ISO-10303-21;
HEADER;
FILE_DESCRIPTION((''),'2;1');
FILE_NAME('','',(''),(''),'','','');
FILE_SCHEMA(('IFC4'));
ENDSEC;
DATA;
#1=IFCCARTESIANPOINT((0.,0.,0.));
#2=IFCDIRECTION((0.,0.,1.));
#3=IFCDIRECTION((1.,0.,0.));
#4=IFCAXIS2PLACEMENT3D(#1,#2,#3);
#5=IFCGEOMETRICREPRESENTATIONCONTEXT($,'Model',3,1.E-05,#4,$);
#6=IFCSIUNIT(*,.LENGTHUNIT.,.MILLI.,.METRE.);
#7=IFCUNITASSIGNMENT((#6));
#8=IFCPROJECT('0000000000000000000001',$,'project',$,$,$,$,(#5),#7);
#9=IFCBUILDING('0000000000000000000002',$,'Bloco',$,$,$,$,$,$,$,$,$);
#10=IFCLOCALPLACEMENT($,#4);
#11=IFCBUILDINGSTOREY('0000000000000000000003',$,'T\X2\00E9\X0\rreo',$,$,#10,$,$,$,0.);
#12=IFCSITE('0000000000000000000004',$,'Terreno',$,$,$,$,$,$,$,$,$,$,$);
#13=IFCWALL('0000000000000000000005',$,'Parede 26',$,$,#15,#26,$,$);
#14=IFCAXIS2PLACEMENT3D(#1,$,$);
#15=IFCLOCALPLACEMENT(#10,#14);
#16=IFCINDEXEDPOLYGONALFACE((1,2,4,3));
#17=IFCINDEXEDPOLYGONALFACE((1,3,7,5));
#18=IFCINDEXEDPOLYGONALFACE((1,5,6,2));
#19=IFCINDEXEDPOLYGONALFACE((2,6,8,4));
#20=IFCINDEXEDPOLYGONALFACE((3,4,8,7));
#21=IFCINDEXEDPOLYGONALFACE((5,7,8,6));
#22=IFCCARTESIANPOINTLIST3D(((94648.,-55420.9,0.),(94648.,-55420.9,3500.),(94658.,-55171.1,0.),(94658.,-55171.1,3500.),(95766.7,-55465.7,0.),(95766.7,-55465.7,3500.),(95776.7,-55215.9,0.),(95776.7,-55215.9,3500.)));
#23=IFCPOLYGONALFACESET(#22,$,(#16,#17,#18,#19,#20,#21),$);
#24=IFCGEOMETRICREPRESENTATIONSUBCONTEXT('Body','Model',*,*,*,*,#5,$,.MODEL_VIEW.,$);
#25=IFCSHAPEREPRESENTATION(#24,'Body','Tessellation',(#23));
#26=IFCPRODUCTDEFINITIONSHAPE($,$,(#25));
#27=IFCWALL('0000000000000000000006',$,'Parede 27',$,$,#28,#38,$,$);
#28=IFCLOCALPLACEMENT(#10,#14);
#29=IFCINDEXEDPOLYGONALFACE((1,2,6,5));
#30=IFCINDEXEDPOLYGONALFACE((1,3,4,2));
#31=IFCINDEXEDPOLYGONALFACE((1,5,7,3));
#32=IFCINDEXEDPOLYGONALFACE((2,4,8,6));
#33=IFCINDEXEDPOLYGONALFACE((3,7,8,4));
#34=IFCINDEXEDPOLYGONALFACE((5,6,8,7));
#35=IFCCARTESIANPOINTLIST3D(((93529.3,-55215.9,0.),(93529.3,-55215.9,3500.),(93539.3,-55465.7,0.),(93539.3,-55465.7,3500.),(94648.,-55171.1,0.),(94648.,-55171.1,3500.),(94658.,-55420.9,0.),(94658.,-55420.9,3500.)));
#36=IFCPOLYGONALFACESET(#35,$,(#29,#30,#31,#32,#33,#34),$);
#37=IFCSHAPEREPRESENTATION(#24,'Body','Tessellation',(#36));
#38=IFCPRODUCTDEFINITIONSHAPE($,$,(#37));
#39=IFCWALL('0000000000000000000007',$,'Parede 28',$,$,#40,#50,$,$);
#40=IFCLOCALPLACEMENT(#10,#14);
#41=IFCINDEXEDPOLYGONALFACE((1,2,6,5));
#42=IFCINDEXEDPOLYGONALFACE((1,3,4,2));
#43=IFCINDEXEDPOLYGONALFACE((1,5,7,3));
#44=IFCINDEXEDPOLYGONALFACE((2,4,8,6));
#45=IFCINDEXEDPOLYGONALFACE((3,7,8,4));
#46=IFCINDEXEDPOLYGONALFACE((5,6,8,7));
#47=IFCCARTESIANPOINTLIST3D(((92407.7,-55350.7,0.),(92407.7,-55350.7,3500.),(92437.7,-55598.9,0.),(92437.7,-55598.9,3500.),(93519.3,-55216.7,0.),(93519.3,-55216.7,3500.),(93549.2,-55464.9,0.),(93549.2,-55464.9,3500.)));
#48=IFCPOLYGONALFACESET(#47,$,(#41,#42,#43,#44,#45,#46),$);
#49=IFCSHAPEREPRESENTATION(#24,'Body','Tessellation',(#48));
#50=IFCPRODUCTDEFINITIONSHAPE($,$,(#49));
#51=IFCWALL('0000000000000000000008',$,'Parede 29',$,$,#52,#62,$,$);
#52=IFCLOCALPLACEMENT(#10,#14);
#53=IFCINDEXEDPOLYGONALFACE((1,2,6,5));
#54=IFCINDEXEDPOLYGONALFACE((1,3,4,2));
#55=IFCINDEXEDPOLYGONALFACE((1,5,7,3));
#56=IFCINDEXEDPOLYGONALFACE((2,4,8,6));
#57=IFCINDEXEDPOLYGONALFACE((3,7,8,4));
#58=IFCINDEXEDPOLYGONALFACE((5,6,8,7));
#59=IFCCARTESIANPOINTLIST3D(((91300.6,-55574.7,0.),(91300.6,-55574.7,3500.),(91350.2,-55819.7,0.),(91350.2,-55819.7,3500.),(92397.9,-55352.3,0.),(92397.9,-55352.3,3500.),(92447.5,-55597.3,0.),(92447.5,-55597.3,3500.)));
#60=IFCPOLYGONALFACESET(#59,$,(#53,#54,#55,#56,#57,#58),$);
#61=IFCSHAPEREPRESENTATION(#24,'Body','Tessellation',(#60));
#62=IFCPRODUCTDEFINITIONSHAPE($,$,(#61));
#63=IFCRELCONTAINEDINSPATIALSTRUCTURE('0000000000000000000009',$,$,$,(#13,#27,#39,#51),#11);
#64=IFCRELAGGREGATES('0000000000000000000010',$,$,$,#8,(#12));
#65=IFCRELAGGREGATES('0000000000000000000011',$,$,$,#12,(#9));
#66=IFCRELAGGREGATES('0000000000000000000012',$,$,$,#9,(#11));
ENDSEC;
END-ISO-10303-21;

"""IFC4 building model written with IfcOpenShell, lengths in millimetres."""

from ifc_helpers import new_model, si_unit, origin, origin_with_axes, place, context, subcontext, project, spatial, polyline, outline, extrude, element, save


model = new_model("IFC4")

# Units and contexts
model_context = context("Model", 3, precision=1e-05, world=origin_with_axes())
body_context = subcontext(model_context, "Body", "Model", "MODEL_VIEW")
ifc_project = project(units=[si_unit("LENGTHUNIT", "METRE", prefix="MILLI")], contexts=[model_context])

# Site, building, storey
site = spatial("IfcSite", under=ifc_project, Name="Terreno")
building = spatial("IfcBuilding", under=site, Name="Bloco")
storey_placement = place(None, origin_with_axes())
storey = spatial("IfcBuildingStorey", under=building, at=storey_placement, Name="Térreo", Elevation=0.0)

# Walls
wall_1_placement = place(storey_placement, origin_with_axes())
element("IfcWall", 1, at=wall_1_placement, inside=storey, Name="Parede 26", context=body_context, shape_type="SweptSolid", body=[
    extrude(outline(polyline([(95766.7, -55465.7), (94648.0, -55420.9), (94658.0, -55171.1), (95776.7, -55215.9), (95766.7, -55465.7)])), origin(), (0.0, 0.0, 1.0), 3500.0),
])
wall_2_placement = place(storey_placement, origin_with_axes())
element("IfcWall", 2, at=wall_2_placement, inside=storey, Name="Parede 27", context=body_context, shape_type="SweptSolid", body=[
    extrude(outline(polyline([(94658.0, -55420.9), (93539.3, -55465.7), (93529.3, -55215.9), (94648.0, -55171.1), (94658.0, -55420.9)])), origin(), (0.0, 0.0, 1.0), 3500.0),
])
wall_3_placement = place(storey_placement, origin_with_axes())
element("IfcWall", 3, at=wall_3_placement, inside=storey, Name="Parede 28", context=body_context, shape_type="SweptSolid", body=[
    extrude(outline(polyline([(93549.2, -55464.9), (92437.7, -55598.9), (92407.7, -55350.7), (93519.3, -55216.7), (93549.2, -55464.9)])), origin(), (0.0, 0.0, 1.0), 3500.0),
])
wall_4_placement = place(storey_placement, origin_with_axes())
element("IfcWall", 4, at=wall_4_placement, inside=storey, Name="Parede 29", context=body_context, shape_type="SweptSolid", body=[
    extrude(outline(polyline([(92447.5, -55597.3), (91350.2, -55819.7), (91300.6, -55574.7), (92397.9, -55352.3), (92447.5, -55597.3)])), origin(), (0.0, 0.0, 1.0), 3500.0),
])

save(model, "model.ifc")
